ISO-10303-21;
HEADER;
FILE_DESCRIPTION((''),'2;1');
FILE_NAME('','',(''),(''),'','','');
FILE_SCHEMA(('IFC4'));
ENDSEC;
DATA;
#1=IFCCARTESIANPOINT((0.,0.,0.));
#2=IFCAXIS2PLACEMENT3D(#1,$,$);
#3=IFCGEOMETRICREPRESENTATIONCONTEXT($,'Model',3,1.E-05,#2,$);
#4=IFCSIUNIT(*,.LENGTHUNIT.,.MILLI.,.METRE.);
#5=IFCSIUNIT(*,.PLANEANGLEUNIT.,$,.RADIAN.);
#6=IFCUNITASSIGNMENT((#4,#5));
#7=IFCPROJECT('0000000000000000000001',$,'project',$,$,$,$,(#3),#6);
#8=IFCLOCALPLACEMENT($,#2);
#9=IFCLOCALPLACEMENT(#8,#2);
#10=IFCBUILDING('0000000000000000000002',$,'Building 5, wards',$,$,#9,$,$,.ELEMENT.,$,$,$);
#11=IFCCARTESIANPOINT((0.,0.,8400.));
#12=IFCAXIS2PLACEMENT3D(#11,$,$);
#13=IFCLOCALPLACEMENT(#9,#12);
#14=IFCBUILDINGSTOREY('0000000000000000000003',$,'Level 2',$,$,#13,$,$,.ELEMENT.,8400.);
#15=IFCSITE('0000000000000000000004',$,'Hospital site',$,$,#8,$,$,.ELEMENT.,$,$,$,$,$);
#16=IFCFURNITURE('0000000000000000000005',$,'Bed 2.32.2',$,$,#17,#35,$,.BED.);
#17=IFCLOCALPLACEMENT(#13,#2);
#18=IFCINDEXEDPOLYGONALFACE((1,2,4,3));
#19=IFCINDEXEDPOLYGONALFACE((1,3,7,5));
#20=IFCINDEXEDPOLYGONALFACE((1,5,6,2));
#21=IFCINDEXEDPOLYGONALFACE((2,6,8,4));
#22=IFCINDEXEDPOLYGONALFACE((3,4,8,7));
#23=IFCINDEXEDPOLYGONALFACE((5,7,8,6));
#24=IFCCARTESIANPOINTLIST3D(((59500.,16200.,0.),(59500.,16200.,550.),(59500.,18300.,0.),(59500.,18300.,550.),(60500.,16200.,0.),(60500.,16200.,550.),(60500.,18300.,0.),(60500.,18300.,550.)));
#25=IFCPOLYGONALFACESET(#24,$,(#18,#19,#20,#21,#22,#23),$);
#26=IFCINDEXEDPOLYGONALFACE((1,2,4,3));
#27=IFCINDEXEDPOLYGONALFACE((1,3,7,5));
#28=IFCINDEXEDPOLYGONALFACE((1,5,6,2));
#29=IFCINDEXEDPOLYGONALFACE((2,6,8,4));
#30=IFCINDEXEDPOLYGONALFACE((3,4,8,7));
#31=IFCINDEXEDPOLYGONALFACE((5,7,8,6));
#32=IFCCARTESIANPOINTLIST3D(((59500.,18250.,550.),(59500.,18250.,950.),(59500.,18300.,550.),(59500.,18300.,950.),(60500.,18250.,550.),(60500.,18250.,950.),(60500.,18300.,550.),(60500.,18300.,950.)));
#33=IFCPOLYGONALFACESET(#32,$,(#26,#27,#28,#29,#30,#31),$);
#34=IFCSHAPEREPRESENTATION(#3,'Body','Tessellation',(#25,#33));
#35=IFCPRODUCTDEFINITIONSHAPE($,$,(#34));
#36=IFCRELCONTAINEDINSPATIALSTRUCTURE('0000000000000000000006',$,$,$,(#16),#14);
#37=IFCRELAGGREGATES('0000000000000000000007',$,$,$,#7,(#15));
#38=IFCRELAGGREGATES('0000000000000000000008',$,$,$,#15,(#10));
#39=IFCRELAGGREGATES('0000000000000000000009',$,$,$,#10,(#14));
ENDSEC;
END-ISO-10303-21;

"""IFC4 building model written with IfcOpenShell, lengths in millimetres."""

from ifc_helpers import new_model, si_unit, frame, frame_2d, origin, place, context, project, spatial, rectangle, extrude, element, save


model = new_model("IFC4")

# Units and contexts
model_context = context("Model", 3, precision=1e-05, world=origin())
ifc_project = project(units=[si_unit("LENGTHUNIT", "METRE", prefix="MILLI"), si_unit("PLANEANGLEUNIT", "RADIAN")], contexts=[model_context])

# Site, building, storey
site_placement = place(None, origin())
site = spatial("IfcSite", under=ifc_project, at=site_placement, Name="Hospital site", CompositionType="ELEMENT")
building_placement = place(site_placement, origin())
building = spatial("IfcBuilding", under=site, at=building_placement, Name="Building 5, wards", CompositionType="ELEMENT")
storey_placement = place(building_placement, frame((0.0, 0.0, 8400.0)))
storey = spatial("IfcBuildingStorey", under=building, at=storey_placement, Name="Level 2", CompositionType="ELEMENT", Elevation=8400.0)

# Furniture
furniture_placement = place(storey_placement, frame((59500.0, 16200.0, 0.0)))
element("IfcFurniture", 1, at=furniture_placement, inside=storey, Name="Bed 2.32.2", PredefinedType="BED", context=model_context, shape_type="SweptSolid", body=[
    extrude(rectangle(XDim=1000.0, YDim=2100.0, at=frame_2d((500.0, 1050.0))), origin(), (0.0, 0.0, 1.0), 550.0),
    extrude(rectangle(XDim=1000.0, YDim=50.0, at=frame_2d((500.0, 2075.0))), frame((0.0, 0.0, 550.0)), (0.0, 0.0, 1.0), 400.0),
])

save(model, "model.ifc")
